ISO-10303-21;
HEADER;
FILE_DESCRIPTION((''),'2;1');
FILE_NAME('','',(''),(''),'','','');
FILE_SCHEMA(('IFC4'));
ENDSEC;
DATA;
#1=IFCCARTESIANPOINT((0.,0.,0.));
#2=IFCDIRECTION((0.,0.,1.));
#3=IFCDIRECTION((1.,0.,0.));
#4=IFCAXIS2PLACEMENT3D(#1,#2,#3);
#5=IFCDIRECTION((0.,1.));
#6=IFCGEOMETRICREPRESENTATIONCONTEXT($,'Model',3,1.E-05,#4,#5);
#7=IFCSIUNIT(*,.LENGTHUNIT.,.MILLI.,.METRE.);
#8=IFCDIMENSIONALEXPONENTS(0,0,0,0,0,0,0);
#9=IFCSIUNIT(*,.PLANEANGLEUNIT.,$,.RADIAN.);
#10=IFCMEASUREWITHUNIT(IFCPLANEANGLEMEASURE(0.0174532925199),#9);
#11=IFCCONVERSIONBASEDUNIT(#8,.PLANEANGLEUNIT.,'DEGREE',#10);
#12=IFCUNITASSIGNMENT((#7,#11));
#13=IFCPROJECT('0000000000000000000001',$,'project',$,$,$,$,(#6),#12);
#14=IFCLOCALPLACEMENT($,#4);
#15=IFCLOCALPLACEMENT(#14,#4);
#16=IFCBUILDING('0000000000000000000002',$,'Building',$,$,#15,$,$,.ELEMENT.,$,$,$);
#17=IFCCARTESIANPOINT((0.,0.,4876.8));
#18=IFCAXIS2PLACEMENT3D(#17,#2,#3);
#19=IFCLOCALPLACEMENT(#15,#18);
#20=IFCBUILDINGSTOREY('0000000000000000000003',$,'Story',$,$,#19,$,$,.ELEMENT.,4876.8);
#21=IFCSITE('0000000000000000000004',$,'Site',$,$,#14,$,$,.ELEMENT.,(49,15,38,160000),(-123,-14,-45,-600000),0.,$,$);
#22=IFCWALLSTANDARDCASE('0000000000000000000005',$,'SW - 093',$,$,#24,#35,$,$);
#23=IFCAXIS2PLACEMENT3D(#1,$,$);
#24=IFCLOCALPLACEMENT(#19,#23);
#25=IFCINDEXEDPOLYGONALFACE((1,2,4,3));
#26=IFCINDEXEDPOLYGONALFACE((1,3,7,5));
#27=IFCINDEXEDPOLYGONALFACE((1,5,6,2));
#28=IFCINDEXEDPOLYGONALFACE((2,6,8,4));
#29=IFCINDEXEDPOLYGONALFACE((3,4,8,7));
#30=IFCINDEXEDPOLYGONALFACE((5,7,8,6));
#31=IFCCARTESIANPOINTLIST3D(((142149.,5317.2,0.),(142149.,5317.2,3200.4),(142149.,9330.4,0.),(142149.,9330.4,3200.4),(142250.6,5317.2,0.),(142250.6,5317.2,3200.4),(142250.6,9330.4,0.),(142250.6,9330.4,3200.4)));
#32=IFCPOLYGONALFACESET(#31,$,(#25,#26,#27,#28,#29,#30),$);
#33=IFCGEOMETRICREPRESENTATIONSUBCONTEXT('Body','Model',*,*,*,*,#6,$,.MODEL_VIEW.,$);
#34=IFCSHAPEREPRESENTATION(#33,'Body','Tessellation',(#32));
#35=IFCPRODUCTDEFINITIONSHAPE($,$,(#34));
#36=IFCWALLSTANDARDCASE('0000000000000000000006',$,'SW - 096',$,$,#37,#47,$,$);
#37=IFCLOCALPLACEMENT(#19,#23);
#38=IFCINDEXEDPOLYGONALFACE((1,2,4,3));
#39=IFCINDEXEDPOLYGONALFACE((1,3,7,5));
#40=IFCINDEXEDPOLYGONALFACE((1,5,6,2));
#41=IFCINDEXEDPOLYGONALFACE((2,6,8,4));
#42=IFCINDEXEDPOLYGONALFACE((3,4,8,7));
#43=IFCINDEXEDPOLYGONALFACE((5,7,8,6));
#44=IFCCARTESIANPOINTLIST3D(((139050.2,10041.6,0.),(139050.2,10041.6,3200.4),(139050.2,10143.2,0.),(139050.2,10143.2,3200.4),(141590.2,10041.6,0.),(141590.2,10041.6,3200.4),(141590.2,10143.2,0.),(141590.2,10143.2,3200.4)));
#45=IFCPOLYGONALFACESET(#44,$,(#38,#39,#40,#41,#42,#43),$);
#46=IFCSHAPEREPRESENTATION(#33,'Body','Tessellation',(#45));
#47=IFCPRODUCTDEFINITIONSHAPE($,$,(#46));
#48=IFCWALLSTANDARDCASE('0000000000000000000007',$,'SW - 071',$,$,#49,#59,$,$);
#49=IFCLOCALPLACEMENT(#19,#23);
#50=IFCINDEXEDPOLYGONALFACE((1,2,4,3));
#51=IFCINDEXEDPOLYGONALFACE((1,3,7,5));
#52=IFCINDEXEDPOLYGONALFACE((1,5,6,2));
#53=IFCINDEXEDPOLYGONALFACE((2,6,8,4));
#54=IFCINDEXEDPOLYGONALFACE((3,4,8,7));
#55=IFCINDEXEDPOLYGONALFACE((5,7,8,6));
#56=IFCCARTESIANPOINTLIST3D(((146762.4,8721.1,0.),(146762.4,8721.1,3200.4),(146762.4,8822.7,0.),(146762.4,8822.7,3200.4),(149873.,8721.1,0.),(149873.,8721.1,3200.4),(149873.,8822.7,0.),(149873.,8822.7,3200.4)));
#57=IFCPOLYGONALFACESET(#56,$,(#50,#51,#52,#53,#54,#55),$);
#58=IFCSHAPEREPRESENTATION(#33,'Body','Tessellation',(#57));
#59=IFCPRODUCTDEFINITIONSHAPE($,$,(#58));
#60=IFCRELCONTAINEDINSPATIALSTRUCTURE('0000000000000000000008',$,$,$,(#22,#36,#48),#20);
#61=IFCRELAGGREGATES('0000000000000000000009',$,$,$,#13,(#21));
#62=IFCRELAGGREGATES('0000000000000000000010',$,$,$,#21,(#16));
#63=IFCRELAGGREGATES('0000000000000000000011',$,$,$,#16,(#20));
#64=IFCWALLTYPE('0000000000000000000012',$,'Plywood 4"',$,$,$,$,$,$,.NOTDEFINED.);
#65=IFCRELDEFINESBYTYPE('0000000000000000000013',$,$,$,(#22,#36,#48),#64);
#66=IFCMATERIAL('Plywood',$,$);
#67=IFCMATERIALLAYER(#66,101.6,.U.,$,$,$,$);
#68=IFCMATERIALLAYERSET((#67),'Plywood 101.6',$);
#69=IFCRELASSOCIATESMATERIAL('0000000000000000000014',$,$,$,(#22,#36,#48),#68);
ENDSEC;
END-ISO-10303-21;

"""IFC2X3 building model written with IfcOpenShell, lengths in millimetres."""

from ifc_helpers import new_model, entity, si_unit, converted_unit, direction, frame, origin_with_axes, place, context, subcontext, project, spatial, polyline, outline, extrude, material, layer, layer_set, layer_usage, type_object, element, save


model = new_model("IFC2X3")

# Units and contexts
model_context = context("Model", 3, precision=1e-05, world=origin_with_axes(), true_north=direction((0.0, 1.0)))
body_context = subcontext(model_context, "Body", "Model", "MODEL_VIEW")
ifc_project = project(units=[si_unit("LENGTHUNIT", "METRE", prefix="MILLI"), converted_unit("PLANEANGLEUNIT", "DEGREE", entity("IfcPlaneAngleMeasure", 0.0174532925199), si_unit("PLANEANGLEUNIT", "RADIAN"), dimensions=[0, 0, 0, 0, 0, 0, 0])], contexts=[model_context])

# Site, building, storey
site_placement = place(None, origin_with_axes())
site = spatial("IfcSite", under=ifc_project, at=site_placement, Name="Site", CompositionType="ELEMENT", RefLatitude=(49, 15, 38, 160000), RefLongitude=(-123, -14, -45, -600000), RefElevation=0.0)
building_placement = place(site_placement, origin_with_axes())
building = spatial("IfcBuilding", under=site, at=building_placement, Name="Building", CompositionType="ELEMENT")
storey_placement = place(building_placement, frame((0.0, 0.0, 4876.8), z_axis=(0.0, 0.0, 1.0), x_axis=(1.0, 0.0, 0.0)))
storey = spatial("IfcBuildingStorey", under=building, at=storey_placement, Name="Story", CompositionType="ELEMENT", Elevation=4876.8)

# Shared definitions
ifc_material_1 = material(Name="Plywood")

# Walls
ifc_layer_1 = layer(ifc_material_1, 101.6, ventilated="UNKNOWN")
ifc_layer_set_1 = layer_set([ifc_layer_1], Name="Plywood 101.6")
ifc_layer_usage_1 = layer_usage(ifc_layer_set_1, "AXIS2", "NEGATIVE", 0.0)
wall_type_1 = type_object("IfcWallType", Name="Plywood 4\"", PredefinedType="NOTDEFINED")
wall_1_placement = place(storey_placement, frame((142149.0, 5317.2, 0.0), z_axis=(0.0, 0.0, 1.0), x_axis=(0.0, 1.0, 0.0)))
element("IfcWallStandardCase", 1, at=wall_1_placement, inside=storey, type_object=wall_type_1, material=ifc_layer_usage_1, Name="SW - 093", context=body_context, shape_type="SweptSolid", body=[
    extrude(outline(polyline([(0.0, -101.6), (4013.2, -101.6), (4013.2, 0.0), (0.0, 0.0), (0.0, -101.6)])), origin_with_axes(), (0.0, 0.0, 1.0), 3200.4),
])
ifc_layer_usage_2 = layer_usage(ifc_layer_set_1, "AXIS2", "NEGATIVE", 0.0)
wall_2_placement = place(storey_placement, frame((141590.2, 10041.6, 0.0), z_axis=(0.0, 0.0, 1.0), x_axis=(-1.0, 0.0, 0.0)))
element("IfcWallStandardCase", 2, at=wall_2_placement, inside=storey, type_object=wall_type_1, material=ifc_layer_usage_2, Name="SW - 096", context=body_context, shape_type="SweptSolid", body=[
    extrude(outline(polyline([(0.0, -101.6), (2540.0, -101.6), (2540.0, 0.0), (0.0, 0.0), (0.0, -101.6)])), origin_with_axes(), (0.0, 0.0, 1.0), 3200.4),
])

# Wall
ifc_layer_usage_3 = layer_usage(ifc_layer_set_1, "AXIS2", "POSITIVE", 0.0)
wall_3_placement = place(storey_placement, frame((146762.4, 8721.1, 0.0), z_axis=(0.0, 0.0, 1.0), x_axis=(1.0, 0.0, 0.0)))
element("IfcWallStandardCase", 3, at=wall_3_placement, inside=storey, type_object=wall_type_1, material=ifc_layer_usage_3, Name="SW - 071", context=body_context, shape_type="SweptSolid", body=[
    extrude(outline(polyline([(0.0, 0.0), (3110.6, 0.0), (3110.6, 101.6), (0.0, 101.6), (0.0, 0.0)])), origin_with_axes(), (0.0, 0.0, 1.0), 3200.4),
])

save(model, "model.ifc")
